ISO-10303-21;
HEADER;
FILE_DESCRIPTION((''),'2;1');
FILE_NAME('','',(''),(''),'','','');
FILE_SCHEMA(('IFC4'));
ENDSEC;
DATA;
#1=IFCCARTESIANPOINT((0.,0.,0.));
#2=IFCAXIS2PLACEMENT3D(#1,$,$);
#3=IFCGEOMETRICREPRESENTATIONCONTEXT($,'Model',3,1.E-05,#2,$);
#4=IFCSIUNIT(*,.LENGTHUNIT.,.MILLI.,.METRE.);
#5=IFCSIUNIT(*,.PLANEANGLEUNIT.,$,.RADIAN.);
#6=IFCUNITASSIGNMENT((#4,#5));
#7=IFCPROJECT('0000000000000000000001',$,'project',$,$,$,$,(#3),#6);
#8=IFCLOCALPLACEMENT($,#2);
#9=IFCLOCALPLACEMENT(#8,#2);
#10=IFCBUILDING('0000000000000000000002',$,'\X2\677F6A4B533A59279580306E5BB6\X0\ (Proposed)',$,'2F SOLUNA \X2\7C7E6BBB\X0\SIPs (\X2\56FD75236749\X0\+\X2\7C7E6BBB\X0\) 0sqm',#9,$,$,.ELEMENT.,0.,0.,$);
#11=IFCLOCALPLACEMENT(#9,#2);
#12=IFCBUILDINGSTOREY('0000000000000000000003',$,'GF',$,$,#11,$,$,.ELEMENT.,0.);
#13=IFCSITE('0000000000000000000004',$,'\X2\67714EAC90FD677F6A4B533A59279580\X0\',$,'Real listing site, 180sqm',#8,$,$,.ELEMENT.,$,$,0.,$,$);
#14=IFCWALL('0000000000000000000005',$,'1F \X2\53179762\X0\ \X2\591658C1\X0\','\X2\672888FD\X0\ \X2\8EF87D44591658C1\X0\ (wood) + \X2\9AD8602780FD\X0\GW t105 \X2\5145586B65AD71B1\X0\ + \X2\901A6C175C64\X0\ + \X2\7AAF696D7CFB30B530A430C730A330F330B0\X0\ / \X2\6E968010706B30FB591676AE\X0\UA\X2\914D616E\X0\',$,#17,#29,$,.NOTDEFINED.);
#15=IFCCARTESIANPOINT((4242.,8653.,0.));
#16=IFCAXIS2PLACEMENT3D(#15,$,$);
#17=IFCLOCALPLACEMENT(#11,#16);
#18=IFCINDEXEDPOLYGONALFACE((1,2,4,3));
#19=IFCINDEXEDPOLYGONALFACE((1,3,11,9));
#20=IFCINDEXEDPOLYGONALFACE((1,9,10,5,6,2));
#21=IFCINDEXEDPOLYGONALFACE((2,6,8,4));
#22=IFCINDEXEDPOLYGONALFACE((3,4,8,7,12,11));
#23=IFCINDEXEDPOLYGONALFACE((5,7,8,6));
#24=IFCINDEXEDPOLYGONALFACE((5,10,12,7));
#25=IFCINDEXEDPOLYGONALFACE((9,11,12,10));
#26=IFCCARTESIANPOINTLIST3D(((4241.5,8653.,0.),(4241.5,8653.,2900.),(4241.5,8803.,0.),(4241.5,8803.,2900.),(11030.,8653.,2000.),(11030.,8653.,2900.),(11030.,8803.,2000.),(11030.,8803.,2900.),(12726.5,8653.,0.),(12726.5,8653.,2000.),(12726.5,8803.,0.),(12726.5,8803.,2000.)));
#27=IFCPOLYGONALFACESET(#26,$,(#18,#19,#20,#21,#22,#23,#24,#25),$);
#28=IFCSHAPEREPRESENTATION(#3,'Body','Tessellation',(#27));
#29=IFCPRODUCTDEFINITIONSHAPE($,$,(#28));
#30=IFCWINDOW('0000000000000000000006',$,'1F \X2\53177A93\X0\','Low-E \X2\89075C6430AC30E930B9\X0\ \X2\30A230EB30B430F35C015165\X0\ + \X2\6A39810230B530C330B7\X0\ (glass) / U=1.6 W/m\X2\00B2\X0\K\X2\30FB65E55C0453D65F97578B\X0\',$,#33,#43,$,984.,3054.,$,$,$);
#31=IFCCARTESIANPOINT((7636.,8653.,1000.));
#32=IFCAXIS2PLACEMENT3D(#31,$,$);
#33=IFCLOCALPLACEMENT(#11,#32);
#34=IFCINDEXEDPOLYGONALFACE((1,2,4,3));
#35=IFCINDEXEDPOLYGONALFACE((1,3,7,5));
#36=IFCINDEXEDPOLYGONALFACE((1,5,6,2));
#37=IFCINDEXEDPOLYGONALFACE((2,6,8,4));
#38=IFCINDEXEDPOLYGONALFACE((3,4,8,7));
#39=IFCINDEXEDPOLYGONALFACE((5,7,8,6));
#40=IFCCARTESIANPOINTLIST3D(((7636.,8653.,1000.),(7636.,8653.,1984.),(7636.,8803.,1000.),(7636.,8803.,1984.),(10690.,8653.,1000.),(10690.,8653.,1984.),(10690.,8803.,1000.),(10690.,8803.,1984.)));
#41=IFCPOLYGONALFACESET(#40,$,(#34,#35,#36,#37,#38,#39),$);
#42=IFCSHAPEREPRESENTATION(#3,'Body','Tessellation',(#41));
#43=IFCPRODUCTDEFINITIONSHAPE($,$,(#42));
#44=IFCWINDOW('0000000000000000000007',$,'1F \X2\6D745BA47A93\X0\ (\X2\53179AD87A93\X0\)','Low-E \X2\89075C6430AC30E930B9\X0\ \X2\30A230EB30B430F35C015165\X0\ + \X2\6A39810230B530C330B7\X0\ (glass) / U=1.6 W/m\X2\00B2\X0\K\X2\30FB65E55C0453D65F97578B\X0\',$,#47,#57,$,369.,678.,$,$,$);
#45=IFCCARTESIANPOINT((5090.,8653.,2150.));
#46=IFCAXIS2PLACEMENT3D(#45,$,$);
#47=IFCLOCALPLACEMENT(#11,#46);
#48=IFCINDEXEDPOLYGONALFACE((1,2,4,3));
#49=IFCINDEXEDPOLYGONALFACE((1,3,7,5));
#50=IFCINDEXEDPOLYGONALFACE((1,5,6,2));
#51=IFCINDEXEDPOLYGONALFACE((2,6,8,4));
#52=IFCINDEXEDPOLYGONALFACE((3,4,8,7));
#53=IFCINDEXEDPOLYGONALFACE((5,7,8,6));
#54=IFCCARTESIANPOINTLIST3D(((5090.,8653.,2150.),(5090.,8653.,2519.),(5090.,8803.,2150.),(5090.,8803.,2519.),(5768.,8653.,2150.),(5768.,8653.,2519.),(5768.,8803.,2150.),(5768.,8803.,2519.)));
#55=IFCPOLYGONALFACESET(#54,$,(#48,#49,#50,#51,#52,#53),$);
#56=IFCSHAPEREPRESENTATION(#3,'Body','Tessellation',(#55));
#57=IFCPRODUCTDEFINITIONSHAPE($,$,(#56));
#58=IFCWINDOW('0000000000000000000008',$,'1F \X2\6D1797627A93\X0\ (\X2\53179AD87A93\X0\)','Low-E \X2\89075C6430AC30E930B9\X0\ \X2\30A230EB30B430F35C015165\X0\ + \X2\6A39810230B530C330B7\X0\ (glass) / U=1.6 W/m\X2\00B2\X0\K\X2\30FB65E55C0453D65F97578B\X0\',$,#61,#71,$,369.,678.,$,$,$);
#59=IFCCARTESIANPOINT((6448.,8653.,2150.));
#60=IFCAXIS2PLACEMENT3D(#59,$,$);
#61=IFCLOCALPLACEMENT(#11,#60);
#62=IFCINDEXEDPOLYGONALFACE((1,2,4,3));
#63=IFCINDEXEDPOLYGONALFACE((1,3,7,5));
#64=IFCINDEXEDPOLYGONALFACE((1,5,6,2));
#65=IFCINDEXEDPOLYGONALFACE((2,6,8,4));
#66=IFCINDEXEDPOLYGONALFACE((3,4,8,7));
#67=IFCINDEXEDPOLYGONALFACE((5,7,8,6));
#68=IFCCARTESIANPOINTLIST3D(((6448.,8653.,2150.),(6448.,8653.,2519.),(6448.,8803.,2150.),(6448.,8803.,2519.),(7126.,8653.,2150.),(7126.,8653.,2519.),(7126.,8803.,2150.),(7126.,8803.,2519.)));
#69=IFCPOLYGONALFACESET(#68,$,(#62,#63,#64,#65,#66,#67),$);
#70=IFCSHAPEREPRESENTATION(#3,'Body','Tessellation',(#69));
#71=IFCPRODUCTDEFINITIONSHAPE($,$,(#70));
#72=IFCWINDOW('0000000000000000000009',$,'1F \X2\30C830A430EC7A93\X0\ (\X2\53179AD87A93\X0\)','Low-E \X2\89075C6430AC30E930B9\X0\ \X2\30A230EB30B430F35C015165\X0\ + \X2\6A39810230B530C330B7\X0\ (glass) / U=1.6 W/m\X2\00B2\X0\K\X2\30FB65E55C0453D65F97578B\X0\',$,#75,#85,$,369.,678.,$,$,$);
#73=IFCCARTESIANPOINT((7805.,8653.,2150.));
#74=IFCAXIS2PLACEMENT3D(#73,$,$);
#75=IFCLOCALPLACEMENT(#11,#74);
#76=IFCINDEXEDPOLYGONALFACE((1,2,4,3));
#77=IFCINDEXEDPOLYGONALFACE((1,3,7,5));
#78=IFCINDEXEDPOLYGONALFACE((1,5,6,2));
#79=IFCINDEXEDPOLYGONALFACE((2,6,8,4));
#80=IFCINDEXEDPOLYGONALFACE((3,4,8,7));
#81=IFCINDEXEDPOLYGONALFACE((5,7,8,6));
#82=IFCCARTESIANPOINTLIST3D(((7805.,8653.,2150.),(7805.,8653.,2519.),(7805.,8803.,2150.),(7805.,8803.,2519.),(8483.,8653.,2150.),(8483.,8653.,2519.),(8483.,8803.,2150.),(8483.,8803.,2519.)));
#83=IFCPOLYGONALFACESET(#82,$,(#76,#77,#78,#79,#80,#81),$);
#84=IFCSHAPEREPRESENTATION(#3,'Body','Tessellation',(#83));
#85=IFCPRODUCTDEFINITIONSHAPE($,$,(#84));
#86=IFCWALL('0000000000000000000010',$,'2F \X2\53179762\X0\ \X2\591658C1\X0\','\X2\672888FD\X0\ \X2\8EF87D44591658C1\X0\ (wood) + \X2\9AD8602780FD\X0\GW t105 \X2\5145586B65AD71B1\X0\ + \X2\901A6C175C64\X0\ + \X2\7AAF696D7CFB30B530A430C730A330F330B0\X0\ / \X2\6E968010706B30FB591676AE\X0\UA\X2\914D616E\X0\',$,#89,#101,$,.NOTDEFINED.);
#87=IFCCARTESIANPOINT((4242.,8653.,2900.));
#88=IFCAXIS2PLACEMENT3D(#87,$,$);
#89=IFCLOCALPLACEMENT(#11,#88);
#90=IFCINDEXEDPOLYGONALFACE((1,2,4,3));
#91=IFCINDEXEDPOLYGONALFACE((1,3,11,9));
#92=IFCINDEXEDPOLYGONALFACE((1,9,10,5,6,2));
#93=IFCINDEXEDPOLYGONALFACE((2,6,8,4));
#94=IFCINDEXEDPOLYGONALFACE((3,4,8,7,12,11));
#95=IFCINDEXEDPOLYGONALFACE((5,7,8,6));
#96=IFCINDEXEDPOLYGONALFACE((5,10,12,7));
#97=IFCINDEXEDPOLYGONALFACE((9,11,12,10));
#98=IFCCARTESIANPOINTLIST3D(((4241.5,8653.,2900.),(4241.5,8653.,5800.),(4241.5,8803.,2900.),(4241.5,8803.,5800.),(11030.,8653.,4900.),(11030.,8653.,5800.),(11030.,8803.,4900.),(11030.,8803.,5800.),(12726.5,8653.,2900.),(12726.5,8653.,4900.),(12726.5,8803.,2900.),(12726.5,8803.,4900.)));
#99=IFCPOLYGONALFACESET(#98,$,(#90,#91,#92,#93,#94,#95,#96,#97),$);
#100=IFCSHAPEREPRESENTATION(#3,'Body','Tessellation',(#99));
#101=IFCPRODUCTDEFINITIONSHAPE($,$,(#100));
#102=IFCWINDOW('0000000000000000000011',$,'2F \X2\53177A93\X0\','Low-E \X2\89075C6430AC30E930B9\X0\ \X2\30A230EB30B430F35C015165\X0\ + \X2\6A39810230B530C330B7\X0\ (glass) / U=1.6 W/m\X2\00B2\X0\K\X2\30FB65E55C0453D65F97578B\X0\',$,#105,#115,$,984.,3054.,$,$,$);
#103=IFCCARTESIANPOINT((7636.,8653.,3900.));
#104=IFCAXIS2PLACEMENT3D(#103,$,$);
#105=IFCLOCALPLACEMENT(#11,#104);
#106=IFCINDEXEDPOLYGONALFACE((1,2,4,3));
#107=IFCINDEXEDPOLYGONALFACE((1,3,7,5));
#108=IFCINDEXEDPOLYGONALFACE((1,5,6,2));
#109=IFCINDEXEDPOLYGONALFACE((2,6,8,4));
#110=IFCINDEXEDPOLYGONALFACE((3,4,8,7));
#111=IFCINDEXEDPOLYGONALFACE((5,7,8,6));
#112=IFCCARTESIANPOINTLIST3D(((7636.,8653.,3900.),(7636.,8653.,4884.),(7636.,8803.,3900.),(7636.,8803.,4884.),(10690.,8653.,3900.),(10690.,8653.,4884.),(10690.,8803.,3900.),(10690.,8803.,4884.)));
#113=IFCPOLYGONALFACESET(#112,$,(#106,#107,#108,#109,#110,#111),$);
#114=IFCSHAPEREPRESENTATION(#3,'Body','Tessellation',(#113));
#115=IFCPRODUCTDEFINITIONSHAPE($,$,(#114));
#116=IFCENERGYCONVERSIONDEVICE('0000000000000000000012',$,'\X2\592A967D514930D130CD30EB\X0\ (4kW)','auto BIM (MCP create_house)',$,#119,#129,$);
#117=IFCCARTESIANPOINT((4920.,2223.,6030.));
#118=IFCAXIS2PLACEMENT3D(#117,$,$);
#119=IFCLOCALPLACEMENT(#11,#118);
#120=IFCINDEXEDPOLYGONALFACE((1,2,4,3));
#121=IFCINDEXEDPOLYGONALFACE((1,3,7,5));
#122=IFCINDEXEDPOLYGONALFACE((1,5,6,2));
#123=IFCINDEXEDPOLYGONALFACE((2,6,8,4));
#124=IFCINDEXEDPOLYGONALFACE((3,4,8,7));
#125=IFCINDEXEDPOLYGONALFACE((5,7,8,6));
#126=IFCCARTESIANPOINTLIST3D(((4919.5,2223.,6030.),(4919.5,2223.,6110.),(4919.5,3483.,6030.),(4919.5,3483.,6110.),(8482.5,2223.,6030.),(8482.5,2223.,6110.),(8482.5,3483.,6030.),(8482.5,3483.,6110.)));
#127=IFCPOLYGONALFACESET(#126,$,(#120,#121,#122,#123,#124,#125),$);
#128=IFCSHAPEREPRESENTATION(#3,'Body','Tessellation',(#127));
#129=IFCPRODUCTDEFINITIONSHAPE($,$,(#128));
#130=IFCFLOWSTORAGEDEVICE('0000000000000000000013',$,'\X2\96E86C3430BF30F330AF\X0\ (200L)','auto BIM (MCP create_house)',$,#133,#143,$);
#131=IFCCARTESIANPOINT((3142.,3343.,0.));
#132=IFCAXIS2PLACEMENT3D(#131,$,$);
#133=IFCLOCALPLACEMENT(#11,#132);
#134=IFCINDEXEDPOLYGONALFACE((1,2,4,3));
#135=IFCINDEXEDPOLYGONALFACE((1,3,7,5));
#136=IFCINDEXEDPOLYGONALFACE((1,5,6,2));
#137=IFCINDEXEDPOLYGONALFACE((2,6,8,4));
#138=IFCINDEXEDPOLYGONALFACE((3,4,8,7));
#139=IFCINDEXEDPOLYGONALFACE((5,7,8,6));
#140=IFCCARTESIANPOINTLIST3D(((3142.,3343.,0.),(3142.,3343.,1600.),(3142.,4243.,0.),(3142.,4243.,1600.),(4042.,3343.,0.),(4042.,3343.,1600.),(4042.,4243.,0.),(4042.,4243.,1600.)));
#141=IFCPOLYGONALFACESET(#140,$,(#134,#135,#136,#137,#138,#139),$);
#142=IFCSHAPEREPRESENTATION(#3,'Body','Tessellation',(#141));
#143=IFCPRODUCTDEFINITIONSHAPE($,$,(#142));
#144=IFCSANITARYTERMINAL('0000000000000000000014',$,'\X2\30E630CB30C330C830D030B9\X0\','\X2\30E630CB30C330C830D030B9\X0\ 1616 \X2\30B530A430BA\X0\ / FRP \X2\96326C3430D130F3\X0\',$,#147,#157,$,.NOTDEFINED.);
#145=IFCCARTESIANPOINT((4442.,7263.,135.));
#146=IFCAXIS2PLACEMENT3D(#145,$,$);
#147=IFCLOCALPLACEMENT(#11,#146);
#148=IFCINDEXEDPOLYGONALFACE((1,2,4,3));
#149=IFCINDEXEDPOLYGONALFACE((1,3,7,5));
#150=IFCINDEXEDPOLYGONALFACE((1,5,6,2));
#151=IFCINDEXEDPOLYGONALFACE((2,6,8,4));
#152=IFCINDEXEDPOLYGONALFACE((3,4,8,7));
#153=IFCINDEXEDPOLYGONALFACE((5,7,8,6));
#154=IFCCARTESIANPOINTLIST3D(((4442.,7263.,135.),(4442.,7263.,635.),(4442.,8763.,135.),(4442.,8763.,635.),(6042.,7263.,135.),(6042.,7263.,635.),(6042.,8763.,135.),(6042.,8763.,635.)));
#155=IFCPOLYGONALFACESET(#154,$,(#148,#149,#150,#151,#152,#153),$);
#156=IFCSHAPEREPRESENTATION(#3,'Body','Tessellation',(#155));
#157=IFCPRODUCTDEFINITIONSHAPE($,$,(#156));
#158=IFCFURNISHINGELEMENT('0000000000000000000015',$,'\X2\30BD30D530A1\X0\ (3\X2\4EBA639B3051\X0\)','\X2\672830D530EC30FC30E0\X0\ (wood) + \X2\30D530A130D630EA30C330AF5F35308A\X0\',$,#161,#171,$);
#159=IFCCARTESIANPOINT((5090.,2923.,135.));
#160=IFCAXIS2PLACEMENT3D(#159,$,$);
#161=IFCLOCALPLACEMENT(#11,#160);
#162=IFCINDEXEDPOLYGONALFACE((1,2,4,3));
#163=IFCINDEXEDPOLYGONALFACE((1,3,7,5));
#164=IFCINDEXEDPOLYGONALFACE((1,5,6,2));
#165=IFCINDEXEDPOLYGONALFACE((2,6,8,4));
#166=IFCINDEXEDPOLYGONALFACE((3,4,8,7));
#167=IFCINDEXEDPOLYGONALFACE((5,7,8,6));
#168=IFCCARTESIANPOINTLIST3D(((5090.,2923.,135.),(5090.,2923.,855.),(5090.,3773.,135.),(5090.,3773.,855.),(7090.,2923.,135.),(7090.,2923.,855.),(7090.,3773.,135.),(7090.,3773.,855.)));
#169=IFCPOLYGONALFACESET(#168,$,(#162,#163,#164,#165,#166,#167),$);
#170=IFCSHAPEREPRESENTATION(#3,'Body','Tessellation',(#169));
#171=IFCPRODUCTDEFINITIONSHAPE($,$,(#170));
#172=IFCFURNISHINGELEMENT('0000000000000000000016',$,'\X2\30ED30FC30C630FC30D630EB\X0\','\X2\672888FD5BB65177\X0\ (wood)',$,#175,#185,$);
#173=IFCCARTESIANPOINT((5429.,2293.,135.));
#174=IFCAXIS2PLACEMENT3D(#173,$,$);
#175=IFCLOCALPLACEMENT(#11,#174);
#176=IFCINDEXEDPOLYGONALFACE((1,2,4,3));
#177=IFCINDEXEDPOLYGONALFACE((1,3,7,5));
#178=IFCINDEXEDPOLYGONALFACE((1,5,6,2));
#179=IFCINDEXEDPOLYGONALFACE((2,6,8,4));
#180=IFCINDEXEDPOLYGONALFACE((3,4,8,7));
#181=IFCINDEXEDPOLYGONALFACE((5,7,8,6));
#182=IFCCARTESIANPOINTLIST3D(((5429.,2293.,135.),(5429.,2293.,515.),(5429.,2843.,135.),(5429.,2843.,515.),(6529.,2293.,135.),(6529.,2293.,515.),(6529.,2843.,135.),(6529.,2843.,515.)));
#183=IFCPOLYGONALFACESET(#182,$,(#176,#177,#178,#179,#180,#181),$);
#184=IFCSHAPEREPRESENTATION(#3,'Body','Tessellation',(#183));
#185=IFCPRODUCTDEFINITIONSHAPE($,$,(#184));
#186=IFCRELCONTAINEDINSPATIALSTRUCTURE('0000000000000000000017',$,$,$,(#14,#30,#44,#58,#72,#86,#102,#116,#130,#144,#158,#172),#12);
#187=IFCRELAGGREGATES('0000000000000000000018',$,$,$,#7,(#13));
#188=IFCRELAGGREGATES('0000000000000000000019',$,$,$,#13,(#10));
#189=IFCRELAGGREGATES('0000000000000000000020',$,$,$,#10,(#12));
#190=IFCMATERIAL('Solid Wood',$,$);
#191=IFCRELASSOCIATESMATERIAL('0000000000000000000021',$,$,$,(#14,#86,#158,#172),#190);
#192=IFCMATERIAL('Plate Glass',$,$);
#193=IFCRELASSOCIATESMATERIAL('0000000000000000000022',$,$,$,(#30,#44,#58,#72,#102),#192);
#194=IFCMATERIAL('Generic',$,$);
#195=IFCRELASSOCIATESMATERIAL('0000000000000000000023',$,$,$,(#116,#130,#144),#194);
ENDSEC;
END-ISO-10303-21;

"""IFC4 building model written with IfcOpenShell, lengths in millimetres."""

from ifc_helpers import new_model, si_unit, frame, frame_2d, origin, place, context, project, spatial, rectangle, extrude, material, element, fill, save


model = new_model("IFC4")

# Units and contexts
model_context = context("Model", 3, precision=1e-05, world=origin())
ifc_project = project(units=[si_unit("LENGTHUNIT", "METRE", prefix="MILLI"), si_unit("PLANEANGLEUNIT", "RADIAN")], contexts=[model_context])

# Site, building, storey
site_placement = place(None, origin())
site = spatial("IfcSite", under=ifc_project, at=site_placement, Name="東京都板橋区大門", ObjectType="Real listing site, 180sqm", CompositionType="ELEMENT", RefElevation=0.0)
building_placement = place(site_placement, origin())
building = spatial("IfcBuilding", under=site, at=building_placement, Name="板橋区大門の家 (Proposed)", ObjectType="2F SOLUNA 籾殻SIPs (国産杉+籾殻) 0sqm", CompositionType="ELEMENT", ElevationOfRefHeight=0.0, ElevationOfTerrain=0.0)
storey_placement = place(building_placement, origin())
storey = spatial("IfcBuildingStorey", under=building, at=storey_placement, Name="GF", CompositionType="ELEMENT", Elevation=0.0)

# Wall, openings, windows
ifc_material_1 = material(Name="Solid Wood")
wall_1_placement = place(storey_placement, frame((4242.0, 8653.0, 0.0)))
wall_1 = element("IfcWall", 1, at=wall_1_placement, inside=storey, material=ifc_material_1, Name="1F 北面 外壁", Description="木製 軸組外壁 (wood) + 高性能GW t105 充填断熱 + 通気層 + 窯業系サイディング / 準耐火・外皮UA配慮", PredefinedType="NOTDEFINED", context=model_context, shape_type="SweptSolid", body=[
    extrude(rectangle(XDim=8485.0, YDim=150.0, at=frame_2d((4242.0, 75.0))), frame((4242.0, 8653.0, 0.0)), (0.0, 0.0, 1.0), 2900.0),
])
opening_1_placement = place(storey_placement, frame((7636.0, 8653.0, 1000.0)))
opening_1 = element("IfcOpeningElement", 2, at=opening_1_placement, cuts=wall_1, PredefinedType="NOTDEFINED", context=model_context, shape_type="SweptSolid", body=[
    extrude(rectangle(XDim=3054.0, YDim=150.0, at=frame_2d((1527.0, 75.0))), frame((7636.0, 8653.0, 1000.0)), (0.0, 0.0, 1.0), 984.0),
])
opening_2_placement = place(storey_placement, frame((5090.0, 8653.0, 2150.0)))
opening_2 = element("IfcOpeningElement", 3, at=opening_2_placement, cuts=wall_1, PredefinedType="NOTDEFINED", context=model_context, shape_type="SweptSolid", body=[
    extrude(rectangle(XDim=678.0, YDim=150.0, at=frame_2d((339.0, 75.0))), frame((5090.0, 8653.0, 2150.0)), (0.0, 0.0, 1.0), 369.0),
])
opening_3_placement = place(storey_placement, frame((6448.0, 8653.0, 2150.0)))
opening_3 = element("IfcOpeningElement", 4, at=opening_3_placement, cuts=wall_1, PredefinedType="NOTDEFINED", context=model_context, shape_type="SweptSolid", body=[
    extrude(rectangle(XDim=678.0, YDim=150.0, at=frame_2d((339.0, 75.0))), frame((6448.0, 8653.0, 2150.0)), (0.0, 0.0, 1.0), 369.0),
])
opening_4_placement = place(storey_placement, frame((7805.0, 8653.0, 2150.0)))
opening_4 = element("IfcOpeningElement", 5, at=opening_4_placement, cuts=wall_1, PredefinedType="NOTDEFINED", context=model_context, shape_type="SweptSolid", body=[
    extrude(rectangle(XDim=678.0, YDim=150.0, at=frame_2d((339.0, 75.0))), frame((7805.0, 8653.0, 2150.0)), (0.0, 0.0, 1.0), 369.0),
])
ifc_material_2 = material(Name="Plate Glass")
window_1_placement = place(storey_placement, frame((7636.0, 8653.0, 1000.0)))
window_1 = element("IfcWindow", 6, at=window_1_placement, inside=storey, material=ifc_material_2, Name="1F 北窓", Description="Low-E 複層ガラス アルゴン封入 + 樹脂サッシ (glass) / U=1.6 W/m²K・日射取得型", OverallHeight=984.0, OverallWidth=3054.0, context=model_context, shape_type="SweptSolid", body=[
    extrude(rectangle(XDim=3054.0, YDim=150.0, at=frame_2d((1527.0, 75.0))), frame((7636.0, 8653.0, 1000.0)), (0.0, 0.0, 1.0), 984.0),
])
fill(opening_1, window_1)
window_2_placement = place(storey_placement, frame((5090.0, 8653.0, 2150.0)))
window_2 = element("IfcWindow", 7, at=window_2_placement, inside=storey, material=ifc_material_2, Name="1F 浴室窓 (北高窓)", Description="Low-E 複層ガラス アルゴン封入 + 樹脂サッシ (glass) / U=1.6 W/m²K・日射取得型", OverallHeight=369.0, OverallWidth=678.0, context=model_context, shape_type="SweptSolid", body=[
    extrude(rectangle(XDim=678.0, YDim=150.0, at=frame_2d((339.0, 75.0))), frame((5090.0, 8653.0, 2150.0)), (0.0, 0.0, 1.0), 369.0),
])
fill(opening_2, window_2)
window_3_placement = place(storey_placement, frame((6448.0, 8653.0, 2150.0)))
window_3 = element("IfcWindow", 8, at=window_3_placement, inside=storey, material=ifc_material_2, Name="1F 洗面窓 (北高窓)", Description="Low-E 複層ガラス アルゴン封入 + 樹脂サッシ (glass) / U=1.6 W/m²K・日射取得型", OverallHeight=369.0, OverallWidth=678.0, context=model_context, shape_type="SweptSolid", body=[
    extrude(rectangle(XDim=678.0, YDim=150.0, at=frame_2d((339.0, 75.0))), frame((6448.0, 8653.0, 2150.0)), (0.0, 0.0, 1.0), 369.0),
])
fill(opening_3, window_3)
window_4_placement = place(storey_placement, frame((7805.0, 8653.0, 2150.0)))
window_4 = element("IfcWindow", 9, at=window_4_placement, inside=storey, material=ifc_material_2, Name="1F トイレ窓 (北高窓)", Description="Low-E 複層ガラス アルゴン封入 + 樹脂サッシ (glass) / U=1.6 W/m²K・日射取得型", OverallHeight=369.0, OverallWidth=678.0, context=model_context, shape_type="SweptSolid", body=[
    extrude(rectangle(XDim=678.0, YDim=150.0, at=frame_2d((339.0, 75.0))), frame((7805.0, 8653.0, 2150.0)), (0.0, 0.0, 1.0), 369.0),
])
fill(opening_4, window_4)

# Wall, opening, window
wall_2_placement = place(storey_placement, frame((4242.0, 8653.0, 2900.0)))
wall_2 = element("IfcWall", 10, at=wall_2_placement, inside=storey, material=ifc_material_1, Name="2F 北面 外壁", Description="木製 軸組外壁 (wood) + 高性能GW t105 充填断熱 + 通気層 + 窯業系サイディング / 準耐火・外皮UA配慮", PredefinedType="NOTDEFINED", context=model_context, shape_type="SweptSolid", body=[
    extrude(rectangle(XDim=8485.0, YDim=150.0, at=frame_2d((4242.0, 75.0))), frame((4242.0, 8653.0, 2900.0)), (0.0, 0.0, 1.0), 2900.0),
])
opening_5_placement = place(storey_placement, frame((7636.0, 8653.0, 3900.0)))
opening_5 = element("IfcOpeningElement", 11, at=opening_5_placement, cuts=wall_2, PredefinedType="NOTDEFINED", context=model_context, shape_type="SweptSolid", body=[
    extrude(rectangle(XDim=3054.0, YDim=150.0, at=frame_2d((1527.0, 75.0))), frame((7636.0, 8653.0, 3900.0)), (0.0, 0.0, 1.0), 984.0),
])
window_5_placement = place(storey_placement, frame((7636.0, 8653.0, 3900.0)))
window_5 = element("IfcWindow", 12, at=window_5_placement, inside=storey, material=ifc_material_2, Name="2F 北窓", Description="Low-E 複層ガラス アルゴン封入 + 樹脂サッシ (glass) / U=1.6 W/m²K・日射取得型", OverallHeight=984.0, OverallWidth=3054.0, context=model_context, shape_type="SweptSolid", body=[
    extrude(rectangle(XDim=3054.0, YDim=150.0, at=frame_2d((1527.0, 75.0))), frame((7636.0, 8653.0, 3900.0)), (0.0, 0.0, 1.0), 984.0),
])
fill(opening_5, window_5)

# Energy conversion device
ifc_material_3 = material(Name="Generic")
energy_conversion_device_placement = place(storey_placement, frame((4920.0, 2223.0, 6030.0)))
element("IfcEnergyConversionDevice", 13, at=energy_conversion_device_placement, inside=storey, material=ifc_material_3, Name="太陽光パネル (4kW)", Description="auto BIM (MCP create_house)", context=model_context, shape_type="SweptSolid", body=[
    extrude(rectangle(XDim=3563.0, YDim=1260.0, at=frame_2d((1781.0, 630.0))), frame((4920.0, 2223.0, 6030.0)), (0.0, 0.0, 1.0), 80.0),
])

# Flow storage device
flow_storage_device_placement = place(storey_placement, frame((3142.0, 3343.0, 0.0)))
element("IfcFlowStorageDevice", 14, at=flow_storage_device_placement, inside=storey, material=ifc_material_3, Name="雨水タンク (200L)", Description="auto BIM (MCP create_house)", context=model_context, shape_type="SweptSolid", body=[
    extrude(rectangle(XDim=900.0, YDim=900.0, at=frame_2d((450.0, 450.0))), frame((3142.0, 3343.0, 0.0)), (0.0, 0.0, 1.0), 1600.0),
])

# Sanitary terminal
sanitary_terminal_placement = place(storey_placement, frame((4442.0, 7263.0, 135.0)))
element("IfcSanitaryTerminal", 15, at=sanitary_terminal_placement, inside=storey, material=ifc_material_3, Name="ユニットバス", Description="ユニットバス 1616 サイズ / FRP 防水パン", PredefinedType="NOTDEFINED", context=model_context, shape_type="SweptSolid", body=[
    extrude(rectangle(XDim=1600.0, YDim=1500.0, at=frame_2d((800.0, 750.0))), frame((4442.0, 7263.0, 135.0)), (0.0, 0.0, 1.0), 500.0),
])

# Furnishing elements
furnishing_1_placement = place(storey_placement, frame((5090.0, 2923.0, 135.0)))
element("IfcFurnishingElement", 16, at=furnishing_1_placement, inside=storey, material=ifc_material_1, Name="ソファ (3人掛け)", Description="木フレーム (wood) + ファブリック張り", context=model_context, shape_type="SweptSolid", body=[
    extrude(rectangle(XDim=2000.0, YDim=850.0, at=frame_2d((1000.0, 425.0))), frame((5090.0, 2923.0, 135.0)), (0.0, 0.0, 1.0), 720.0),
])
furnishing_2_placement = place(storey_placement, frame((5429.0, 2293.0, 135.0)))
element("IfcFurnishingElement", 17, at=furnishing_2_placement, inside=storey, material=ifc_material_1, Name="ローテーブル", Description="木製家具 (wood)", context=model_context, shape_type="SweptSolid", body=[
    extrude(rectangle(XDim=1100.0, YDim=550.0, at=frame_2d((550.0, 275.0))), frame((5429.0, 2293.0, 135.0)), (0.0, 0.0, 1.0), 380.0),
])

save(model, "model.ifc")
